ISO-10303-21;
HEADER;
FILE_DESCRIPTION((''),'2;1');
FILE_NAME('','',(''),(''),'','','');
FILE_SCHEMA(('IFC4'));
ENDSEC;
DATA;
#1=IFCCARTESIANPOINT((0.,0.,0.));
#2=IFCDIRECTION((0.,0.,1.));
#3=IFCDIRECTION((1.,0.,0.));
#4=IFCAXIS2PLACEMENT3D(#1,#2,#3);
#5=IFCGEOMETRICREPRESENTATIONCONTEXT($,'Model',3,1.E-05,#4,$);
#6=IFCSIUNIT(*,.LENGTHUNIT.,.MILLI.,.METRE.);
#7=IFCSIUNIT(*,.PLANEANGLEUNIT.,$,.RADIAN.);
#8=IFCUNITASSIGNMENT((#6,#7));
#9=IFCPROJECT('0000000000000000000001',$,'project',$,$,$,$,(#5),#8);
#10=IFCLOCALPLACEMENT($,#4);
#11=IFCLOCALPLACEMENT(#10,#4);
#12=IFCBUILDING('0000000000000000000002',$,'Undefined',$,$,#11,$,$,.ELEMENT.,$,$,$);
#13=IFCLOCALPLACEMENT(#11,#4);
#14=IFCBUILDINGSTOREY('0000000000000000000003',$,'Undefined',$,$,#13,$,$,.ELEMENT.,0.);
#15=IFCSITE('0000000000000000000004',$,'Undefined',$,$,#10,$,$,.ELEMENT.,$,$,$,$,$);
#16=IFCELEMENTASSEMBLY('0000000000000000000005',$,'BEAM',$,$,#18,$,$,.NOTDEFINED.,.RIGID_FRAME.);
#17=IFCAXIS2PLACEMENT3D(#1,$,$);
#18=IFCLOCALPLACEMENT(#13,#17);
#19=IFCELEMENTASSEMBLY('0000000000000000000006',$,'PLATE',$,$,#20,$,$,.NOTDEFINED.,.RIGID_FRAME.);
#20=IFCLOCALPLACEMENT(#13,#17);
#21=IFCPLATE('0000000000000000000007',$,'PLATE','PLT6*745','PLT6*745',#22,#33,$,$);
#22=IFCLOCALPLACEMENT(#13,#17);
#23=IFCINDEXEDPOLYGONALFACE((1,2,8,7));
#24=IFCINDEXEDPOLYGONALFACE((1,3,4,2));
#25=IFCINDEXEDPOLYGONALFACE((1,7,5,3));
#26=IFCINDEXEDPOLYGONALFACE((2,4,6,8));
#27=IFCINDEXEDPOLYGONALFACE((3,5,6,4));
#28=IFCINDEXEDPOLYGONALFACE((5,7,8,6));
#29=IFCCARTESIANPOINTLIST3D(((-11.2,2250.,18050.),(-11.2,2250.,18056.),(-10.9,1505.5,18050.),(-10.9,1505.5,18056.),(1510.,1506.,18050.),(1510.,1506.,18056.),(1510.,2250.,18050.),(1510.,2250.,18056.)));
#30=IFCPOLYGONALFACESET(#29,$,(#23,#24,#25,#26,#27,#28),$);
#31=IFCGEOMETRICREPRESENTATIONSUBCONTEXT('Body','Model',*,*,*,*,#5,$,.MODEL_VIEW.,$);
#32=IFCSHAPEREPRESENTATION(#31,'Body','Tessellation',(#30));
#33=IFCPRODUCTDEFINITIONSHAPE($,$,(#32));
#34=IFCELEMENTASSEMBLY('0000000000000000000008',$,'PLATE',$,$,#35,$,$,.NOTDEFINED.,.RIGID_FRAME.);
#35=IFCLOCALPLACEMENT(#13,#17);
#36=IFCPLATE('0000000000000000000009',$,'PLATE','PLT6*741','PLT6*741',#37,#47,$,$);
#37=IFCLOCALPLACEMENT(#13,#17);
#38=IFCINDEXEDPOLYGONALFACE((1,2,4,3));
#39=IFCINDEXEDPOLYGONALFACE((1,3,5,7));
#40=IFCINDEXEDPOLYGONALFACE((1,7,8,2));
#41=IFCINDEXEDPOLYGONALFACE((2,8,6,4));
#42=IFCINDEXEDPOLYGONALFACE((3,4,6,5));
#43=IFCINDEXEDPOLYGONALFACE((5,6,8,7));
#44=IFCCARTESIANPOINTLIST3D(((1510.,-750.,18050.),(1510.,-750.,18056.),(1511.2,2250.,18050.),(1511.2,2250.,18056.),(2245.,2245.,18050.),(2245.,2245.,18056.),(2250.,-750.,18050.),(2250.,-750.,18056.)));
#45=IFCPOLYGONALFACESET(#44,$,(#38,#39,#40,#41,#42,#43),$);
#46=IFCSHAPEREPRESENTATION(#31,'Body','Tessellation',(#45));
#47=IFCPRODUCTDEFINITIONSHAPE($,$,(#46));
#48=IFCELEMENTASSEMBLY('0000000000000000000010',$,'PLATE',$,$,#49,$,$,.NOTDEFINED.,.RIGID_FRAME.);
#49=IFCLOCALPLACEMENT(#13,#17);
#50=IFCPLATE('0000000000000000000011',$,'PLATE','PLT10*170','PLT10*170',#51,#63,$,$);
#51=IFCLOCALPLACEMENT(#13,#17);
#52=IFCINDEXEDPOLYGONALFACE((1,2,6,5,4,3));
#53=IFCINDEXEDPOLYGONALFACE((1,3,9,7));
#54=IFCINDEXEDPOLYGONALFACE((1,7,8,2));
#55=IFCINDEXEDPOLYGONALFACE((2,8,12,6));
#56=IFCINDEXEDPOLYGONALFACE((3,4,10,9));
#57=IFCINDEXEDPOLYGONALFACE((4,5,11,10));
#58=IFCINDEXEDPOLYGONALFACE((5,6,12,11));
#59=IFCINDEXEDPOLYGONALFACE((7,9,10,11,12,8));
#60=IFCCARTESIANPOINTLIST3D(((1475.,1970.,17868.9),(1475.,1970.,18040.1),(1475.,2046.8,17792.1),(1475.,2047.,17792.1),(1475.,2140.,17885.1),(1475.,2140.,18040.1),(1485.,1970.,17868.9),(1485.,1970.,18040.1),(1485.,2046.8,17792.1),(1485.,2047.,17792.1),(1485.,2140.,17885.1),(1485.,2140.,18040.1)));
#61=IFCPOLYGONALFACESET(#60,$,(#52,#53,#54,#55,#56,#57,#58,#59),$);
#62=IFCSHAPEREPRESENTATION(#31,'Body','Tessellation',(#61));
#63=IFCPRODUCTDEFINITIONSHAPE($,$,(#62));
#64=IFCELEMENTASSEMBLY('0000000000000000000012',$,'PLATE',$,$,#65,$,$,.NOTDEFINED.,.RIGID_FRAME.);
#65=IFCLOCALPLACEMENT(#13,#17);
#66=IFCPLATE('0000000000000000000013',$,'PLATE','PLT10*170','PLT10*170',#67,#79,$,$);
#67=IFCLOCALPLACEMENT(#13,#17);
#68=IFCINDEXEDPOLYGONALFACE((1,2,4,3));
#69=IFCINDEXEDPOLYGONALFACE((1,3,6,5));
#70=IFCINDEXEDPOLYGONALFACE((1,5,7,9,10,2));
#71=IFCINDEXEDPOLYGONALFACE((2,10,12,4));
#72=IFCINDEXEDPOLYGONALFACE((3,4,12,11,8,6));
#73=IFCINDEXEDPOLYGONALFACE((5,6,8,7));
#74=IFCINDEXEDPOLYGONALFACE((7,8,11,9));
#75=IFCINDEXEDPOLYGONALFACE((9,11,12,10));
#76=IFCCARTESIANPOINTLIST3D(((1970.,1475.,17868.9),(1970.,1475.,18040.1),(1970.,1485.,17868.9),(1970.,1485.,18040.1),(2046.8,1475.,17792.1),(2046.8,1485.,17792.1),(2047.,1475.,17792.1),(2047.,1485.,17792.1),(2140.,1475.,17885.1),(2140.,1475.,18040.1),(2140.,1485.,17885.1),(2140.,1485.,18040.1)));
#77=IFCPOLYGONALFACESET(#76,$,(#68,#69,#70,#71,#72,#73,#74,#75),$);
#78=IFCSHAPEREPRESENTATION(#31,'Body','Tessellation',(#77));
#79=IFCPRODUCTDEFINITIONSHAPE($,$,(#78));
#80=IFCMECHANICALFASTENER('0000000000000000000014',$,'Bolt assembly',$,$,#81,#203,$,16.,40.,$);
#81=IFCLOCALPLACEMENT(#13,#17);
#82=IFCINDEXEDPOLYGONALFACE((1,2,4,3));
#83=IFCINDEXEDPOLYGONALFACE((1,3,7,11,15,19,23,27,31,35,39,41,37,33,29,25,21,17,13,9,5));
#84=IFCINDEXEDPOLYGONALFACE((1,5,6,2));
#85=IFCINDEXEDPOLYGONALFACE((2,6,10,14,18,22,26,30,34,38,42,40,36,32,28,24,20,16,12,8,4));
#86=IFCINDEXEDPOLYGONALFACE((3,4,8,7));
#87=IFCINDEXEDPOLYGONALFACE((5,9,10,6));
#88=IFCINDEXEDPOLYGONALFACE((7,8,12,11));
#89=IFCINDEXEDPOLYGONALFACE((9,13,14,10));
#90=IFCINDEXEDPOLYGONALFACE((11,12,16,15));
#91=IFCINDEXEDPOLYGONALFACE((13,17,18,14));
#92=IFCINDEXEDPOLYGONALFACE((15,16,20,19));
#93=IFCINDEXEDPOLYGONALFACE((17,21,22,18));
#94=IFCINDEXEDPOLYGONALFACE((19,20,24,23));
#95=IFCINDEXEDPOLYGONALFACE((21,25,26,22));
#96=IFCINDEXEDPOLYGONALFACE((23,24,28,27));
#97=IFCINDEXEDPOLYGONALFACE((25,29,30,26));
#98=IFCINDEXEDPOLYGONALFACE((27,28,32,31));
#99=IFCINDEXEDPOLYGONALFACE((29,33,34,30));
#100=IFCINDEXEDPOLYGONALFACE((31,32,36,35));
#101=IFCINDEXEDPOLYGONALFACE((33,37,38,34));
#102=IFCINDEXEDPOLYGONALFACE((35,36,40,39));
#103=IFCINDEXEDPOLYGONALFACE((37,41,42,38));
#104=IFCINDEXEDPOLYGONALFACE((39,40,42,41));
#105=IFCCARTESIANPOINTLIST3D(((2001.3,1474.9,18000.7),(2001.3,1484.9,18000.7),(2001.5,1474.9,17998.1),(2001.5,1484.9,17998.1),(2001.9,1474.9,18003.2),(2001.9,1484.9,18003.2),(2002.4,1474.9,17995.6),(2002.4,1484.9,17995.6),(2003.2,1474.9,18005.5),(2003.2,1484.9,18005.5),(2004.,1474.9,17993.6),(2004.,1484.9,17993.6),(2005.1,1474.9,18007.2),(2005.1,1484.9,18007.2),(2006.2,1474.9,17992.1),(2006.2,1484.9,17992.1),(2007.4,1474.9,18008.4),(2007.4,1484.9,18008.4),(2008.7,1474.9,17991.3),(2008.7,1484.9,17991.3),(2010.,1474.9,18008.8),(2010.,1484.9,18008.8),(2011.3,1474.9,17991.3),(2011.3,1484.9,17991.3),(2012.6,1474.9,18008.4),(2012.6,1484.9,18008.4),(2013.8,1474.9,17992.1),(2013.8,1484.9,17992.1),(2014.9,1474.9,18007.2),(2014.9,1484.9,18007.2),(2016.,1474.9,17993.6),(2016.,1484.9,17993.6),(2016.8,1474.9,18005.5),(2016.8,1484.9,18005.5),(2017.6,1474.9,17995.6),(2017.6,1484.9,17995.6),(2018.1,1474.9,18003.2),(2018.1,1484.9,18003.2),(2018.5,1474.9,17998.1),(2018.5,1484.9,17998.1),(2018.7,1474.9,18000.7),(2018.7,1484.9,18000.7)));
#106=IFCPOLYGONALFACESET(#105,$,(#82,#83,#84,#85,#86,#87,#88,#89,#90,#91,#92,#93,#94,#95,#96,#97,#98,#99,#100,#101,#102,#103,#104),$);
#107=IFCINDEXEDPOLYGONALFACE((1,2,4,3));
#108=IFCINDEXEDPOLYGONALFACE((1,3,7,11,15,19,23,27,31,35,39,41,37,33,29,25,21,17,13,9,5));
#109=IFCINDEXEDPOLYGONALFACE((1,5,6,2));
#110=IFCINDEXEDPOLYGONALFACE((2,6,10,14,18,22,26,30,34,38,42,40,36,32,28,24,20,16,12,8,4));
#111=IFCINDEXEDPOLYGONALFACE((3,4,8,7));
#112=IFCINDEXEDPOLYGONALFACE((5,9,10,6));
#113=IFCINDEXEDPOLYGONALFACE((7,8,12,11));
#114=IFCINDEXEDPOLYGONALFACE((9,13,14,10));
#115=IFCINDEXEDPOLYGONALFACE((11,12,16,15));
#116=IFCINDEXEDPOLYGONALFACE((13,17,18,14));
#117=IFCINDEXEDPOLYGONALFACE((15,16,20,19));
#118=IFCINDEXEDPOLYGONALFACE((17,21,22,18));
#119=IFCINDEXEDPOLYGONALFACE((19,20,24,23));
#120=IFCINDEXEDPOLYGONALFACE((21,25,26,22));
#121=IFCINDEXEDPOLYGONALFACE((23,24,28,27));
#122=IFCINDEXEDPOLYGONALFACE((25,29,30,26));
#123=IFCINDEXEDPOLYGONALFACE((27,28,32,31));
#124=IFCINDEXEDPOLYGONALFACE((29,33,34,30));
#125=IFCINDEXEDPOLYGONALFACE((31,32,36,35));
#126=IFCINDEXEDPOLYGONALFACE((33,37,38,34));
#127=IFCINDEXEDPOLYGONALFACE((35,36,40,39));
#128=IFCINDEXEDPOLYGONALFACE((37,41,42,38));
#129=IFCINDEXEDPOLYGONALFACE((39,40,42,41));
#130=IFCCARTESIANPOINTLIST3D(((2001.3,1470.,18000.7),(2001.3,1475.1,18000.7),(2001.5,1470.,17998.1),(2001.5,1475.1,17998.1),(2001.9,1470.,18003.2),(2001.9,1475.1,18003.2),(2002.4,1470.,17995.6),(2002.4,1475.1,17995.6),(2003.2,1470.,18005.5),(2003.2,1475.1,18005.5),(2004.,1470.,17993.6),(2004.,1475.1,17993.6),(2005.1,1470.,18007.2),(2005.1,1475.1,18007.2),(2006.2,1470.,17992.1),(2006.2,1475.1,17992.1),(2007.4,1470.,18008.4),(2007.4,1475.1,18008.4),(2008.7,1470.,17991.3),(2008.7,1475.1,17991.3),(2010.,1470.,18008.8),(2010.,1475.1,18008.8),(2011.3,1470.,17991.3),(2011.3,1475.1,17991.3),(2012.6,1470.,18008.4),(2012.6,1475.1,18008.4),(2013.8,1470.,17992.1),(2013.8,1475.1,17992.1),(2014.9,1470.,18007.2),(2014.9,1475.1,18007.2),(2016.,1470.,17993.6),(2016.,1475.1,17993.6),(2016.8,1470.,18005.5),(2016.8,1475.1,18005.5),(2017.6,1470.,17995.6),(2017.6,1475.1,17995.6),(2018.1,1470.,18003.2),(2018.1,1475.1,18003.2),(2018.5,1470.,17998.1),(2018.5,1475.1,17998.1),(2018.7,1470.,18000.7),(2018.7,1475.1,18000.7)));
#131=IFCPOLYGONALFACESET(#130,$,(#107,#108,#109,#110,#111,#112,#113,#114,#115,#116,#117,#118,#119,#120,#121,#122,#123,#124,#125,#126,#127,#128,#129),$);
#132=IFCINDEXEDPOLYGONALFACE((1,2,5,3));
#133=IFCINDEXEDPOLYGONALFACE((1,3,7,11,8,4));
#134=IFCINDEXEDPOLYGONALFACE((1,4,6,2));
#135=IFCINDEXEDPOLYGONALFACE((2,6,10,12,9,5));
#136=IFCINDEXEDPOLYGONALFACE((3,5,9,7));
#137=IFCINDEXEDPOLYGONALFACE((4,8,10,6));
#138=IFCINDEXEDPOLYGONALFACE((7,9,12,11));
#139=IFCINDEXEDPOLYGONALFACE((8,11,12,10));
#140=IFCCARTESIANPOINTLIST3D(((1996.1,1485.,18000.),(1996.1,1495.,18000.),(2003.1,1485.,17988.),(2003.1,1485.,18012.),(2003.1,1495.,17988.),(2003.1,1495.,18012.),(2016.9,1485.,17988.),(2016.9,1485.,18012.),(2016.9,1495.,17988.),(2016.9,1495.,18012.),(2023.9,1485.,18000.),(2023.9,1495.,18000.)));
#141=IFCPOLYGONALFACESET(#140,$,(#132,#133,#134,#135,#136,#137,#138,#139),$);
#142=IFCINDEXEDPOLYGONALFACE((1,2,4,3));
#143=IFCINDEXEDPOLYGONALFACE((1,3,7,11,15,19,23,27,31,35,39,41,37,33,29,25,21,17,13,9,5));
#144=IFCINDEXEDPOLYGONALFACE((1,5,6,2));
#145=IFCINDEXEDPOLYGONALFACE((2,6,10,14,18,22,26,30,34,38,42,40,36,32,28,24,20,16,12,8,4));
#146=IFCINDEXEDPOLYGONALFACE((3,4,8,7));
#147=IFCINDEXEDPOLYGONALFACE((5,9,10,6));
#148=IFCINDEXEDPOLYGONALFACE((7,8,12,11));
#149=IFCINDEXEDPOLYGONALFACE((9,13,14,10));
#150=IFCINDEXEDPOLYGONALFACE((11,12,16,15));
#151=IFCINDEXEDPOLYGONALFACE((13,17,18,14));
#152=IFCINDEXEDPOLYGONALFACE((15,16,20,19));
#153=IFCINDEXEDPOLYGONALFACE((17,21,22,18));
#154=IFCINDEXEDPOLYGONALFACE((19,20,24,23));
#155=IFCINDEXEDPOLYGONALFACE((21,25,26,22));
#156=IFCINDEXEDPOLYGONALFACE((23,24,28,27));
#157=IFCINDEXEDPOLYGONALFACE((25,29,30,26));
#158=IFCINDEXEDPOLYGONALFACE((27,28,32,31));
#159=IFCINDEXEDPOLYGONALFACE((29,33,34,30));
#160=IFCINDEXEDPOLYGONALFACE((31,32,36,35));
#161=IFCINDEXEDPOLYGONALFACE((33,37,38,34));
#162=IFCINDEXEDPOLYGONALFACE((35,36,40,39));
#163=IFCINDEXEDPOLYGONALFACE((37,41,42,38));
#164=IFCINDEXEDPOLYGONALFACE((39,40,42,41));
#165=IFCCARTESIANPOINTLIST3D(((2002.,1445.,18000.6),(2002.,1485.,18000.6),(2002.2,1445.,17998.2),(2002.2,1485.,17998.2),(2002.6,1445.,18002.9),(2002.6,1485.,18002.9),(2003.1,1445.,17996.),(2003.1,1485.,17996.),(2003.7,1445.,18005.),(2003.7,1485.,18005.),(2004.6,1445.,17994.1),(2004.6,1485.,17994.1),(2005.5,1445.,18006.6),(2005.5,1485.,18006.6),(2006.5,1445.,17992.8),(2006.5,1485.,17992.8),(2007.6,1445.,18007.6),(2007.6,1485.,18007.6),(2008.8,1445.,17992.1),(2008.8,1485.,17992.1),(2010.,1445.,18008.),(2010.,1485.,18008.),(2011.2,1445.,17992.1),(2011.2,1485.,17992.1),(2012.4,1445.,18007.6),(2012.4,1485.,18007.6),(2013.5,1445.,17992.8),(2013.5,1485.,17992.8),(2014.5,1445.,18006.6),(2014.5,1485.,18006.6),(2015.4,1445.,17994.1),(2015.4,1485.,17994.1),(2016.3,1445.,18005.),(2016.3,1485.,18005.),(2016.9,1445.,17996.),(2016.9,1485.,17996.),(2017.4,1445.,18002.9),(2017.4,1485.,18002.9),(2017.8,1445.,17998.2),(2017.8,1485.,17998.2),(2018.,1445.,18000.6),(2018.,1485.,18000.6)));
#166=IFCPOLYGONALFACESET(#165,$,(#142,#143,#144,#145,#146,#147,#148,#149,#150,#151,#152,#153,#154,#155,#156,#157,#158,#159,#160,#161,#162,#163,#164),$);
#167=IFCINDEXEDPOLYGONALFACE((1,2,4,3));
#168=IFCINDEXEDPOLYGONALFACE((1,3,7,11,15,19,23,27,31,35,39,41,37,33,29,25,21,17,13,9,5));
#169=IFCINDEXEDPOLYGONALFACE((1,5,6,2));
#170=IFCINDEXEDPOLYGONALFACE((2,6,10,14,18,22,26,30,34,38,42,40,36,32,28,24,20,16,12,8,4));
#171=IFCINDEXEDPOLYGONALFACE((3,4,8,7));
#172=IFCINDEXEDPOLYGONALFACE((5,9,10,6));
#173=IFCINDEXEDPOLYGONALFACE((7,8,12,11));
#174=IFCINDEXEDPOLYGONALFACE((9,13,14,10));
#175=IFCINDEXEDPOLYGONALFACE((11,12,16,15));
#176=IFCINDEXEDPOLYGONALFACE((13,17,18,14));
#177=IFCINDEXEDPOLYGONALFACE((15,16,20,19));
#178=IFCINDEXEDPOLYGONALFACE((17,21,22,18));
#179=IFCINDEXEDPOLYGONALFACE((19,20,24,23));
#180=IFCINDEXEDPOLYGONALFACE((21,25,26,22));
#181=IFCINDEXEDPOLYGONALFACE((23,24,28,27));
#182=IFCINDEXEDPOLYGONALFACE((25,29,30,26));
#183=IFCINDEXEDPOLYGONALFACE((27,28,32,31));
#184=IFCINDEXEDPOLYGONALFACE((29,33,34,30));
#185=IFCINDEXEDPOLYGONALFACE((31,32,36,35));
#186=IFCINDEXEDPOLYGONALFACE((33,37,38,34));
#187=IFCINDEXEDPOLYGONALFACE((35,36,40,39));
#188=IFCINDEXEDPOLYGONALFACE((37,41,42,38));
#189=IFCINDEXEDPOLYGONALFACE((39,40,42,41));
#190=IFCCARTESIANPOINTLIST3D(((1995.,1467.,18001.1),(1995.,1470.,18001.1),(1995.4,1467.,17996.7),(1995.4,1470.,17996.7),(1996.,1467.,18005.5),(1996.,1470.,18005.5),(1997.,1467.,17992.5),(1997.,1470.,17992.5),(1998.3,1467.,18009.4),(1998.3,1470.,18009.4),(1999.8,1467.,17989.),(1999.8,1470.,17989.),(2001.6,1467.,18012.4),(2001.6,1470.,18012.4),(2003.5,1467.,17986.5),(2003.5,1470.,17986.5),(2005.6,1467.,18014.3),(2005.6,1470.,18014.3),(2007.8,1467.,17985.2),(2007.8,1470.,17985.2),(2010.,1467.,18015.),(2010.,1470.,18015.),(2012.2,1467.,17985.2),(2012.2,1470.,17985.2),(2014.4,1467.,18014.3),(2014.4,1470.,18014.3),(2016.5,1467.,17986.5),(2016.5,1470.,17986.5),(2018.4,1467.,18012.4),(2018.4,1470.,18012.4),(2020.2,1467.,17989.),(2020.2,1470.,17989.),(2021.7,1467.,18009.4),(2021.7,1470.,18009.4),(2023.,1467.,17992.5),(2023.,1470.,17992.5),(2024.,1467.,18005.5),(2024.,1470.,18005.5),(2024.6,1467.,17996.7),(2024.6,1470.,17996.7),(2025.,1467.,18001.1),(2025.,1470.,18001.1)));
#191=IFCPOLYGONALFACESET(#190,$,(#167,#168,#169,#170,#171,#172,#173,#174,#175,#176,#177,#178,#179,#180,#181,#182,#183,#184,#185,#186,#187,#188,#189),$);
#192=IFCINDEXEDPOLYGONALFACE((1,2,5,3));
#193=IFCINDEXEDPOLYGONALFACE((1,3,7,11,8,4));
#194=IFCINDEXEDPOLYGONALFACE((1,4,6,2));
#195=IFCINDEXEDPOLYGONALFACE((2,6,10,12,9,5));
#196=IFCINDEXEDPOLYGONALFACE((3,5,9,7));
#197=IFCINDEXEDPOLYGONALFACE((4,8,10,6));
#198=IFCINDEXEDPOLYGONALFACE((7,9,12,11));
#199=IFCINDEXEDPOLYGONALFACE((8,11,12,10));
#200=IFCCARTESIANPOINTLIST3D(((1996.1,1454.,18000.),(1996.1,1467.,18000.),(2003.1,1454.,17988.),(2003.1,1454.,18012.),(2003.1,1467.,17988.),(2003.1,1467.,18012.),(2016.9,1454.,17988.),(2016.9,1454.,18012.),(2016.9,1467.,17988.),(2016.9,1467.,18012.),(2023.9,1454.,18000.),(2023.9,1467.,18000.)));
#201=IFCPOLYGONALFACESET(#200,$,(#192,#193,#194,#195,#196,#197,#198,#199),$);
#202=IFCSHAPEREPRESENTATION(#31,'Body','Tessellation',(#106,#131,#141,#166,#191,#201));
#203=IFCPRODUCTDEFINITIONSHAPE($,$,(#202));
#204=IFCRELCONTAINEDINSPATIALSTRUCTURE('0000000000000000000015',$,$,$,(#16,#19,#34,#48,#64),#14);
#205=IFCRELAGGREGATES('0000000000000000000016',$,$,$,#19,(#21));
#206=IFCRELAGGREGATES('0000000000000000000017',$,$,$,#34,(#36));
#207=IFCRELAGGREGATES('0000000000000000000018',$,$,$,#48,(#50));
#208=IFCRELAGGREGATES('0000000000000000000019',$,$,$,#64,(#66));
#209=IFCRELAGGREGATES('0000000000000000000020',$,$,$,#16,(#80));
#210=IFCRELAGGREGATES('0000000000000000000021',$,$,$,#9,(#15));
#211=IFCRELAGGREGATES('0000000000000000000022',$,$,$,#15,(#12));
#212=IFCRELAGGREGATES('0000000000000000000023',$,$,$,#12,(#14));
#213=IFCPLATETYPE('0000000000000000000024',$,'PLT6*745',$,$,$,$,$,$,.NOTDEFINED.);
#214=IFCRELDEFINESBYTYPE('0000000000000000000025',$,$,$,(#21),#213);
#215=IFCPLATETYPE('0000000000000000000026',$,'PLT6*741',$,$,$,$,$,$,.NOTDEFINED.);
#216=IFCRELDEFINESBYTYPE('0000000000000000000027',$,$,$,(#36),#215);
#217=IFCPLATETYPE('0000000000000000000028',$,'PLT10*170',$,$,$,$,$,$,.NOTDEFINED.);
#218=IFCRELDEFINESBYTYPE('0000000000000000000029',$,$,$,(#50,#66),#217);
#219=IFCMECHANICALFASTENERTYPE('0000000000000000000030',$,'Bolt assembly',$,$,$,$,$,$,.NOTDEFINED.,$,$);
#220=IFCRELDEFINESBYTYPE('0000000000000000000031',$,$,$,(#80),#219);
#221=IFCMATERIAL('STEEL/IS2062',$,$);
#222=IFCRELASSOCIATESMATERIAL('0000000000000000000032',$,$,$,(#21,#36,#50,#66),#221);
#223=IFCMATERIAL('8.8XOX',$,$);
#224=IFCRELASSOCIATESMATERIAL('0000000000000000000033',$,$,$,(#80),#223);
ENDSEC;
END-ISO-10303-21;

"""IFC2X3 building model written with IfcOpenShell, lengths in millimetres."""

from ifc_helpers import new_model, si_unit, frame, origin_with_axes, origin_2d_with_axis, place, context, subcontext, project, spatial, polyline, circle, outline, extrude, source, transform, mapped, material, type_object, element, aggregate, save


model = new_model("IFC2X3")

# Units and contexts
model_context = context("Model", 3, precision=1e-05, world=origin_with_axes())
body_context = subcontext(model_context, "Body", "Model", "MODEL_VIEW")
ifc_project = project(units=[si_unit("LENGTHUNIT", "METRE", prefix="MILLI"), si_unit("PLANEANGLEUNIT", "RADIAN")], contexts=[model_context])

# Site, building, storey
site_placement = place(None, origin_with_axes())
site = spatial("IfcSite", under=ifc_project, at=site_placement, Name="Undefined", CompositionType="ELEMENT")
building_placement = place(site_placement, origin_with_axes())
building = spatial("IfcBuilding", under=site, at=building_placement, Name="Undefined", CompositionType="ELEMENT")
storey_placement = place(building_placement, origin_with_axes())
storey = spatial("IfcBuildingStorey", under=building, at=storey_placement, Name="Undefined", CompositionType="ELEMENT", Elevation=0.0)

# Shared definitions
ifc_material_1 = material(Name="STEEL/IS2062")

# Element assembly
assembly_1_placement = place(storey_placement, origin_with_axes())
assembly_1 = element("IfcElementAssembly", 1, at=assembly_1_placement, inside=storey, Name="BEAM", AssemblyPlace="NOTDEFINED", PredefinedType="RIGID_FRAME")

# Element assemblies, plates
assembly_2_placement = place(storey_placement, origin_with_axes())
assembly_2 = element("IfcElementAssembly", 2, at=assembly_2_placement, inside=storey, Name="PLATE", AssemblyPlace="NOTDEFINED", PredefinedType="RIGID_FRAME")
plate_type_1 = type_object("IfcPlateType", Name="PLT6*745", PredefinedType="NOTDEFINED")
plate_1_placement = place(assembly_2_placement, frame((1510.0, 2250.0, 18053.0), z_axis=(0.0, 0.0, 1.0), x_axis=(-1.0, -0.000026, 0.0)))
plate_1 = element("IfcPlate", 3, at=plate_1_placement, type_object=plate_type_1, material=ifc_material_1, Name="PLATE", Description="PLT6*745", ObjectType="PLT6*745", context=body_context, shape_type="SweptSolid", body=[
    extrude(outline(polyline([(0.0, 0.0), (1521.2, 0.0), (1520.9, 744.5), (0.0, 744.0), (0.0, 0.0)])), frame((0.0, 0.0, -3.0), z_axis=(0.0, 0.0, 1.0), x_axis=(1.0, 0.0, 0.0)), (0.0, 0.0, 1.0), 6.0),
])
aggregate(assembly_2, [plate_1])
assembly_3_placement = place(storey_placement, origin_with_axes())
assembly_3 = element("IfcElementAssembly", 4, at=assembly_3_placement, inside=storey, Name="PLATE", AssemblyPlace="NOTDEFINED", PredefinedType="RIGID_FRAME")
plate_type_2 = type_object("IfcPlateType", Name="PLT6*741", PredefinedType="NOTDEFINED")
plate_2_placement = place(assembly_3_placement, frame((1510.0, 2250.0, 18053.0), z_axis=(0.0, 0.0, -1.0), x_axis=(0.999977, -0.006803, 0.0)))
plate_2 = element("IfcPlate", 5, at=plate_2_placement, type_object=plate_type_2, material=ifc_material_1, Name="PLATE", Description="PLT6*741", ObjectType="PLT6*741", context=body_context, shape_type="SweptSolid", body=[
    extrude(outline(polyline([(0.0, 0.0), (735.0, 0.0), (760.4, 2994.9), (20.4, 2999.9), (1.2, 0.0), (0.0, 0.0)])), frame((0.0, 0.0, -3.0), z_axis=(0.0, 0.0, 1.0), x_axis=(1.0, 0.0, 0.0)), (0.0, 0.0, 1.0), 6.0),
])
aggregate(assembly_3, [plate_2])
assembly_4_placement = place(storey_placement, origin_with_axes())
assembly_4 = element("IfcElementAssembly", 6, at=assembly_4_placement, inside=storey, Name="PLATE", AssemblyPlace="NOTDEFINED", PredefinedType="RIGID_FRAME")
plate_type_3 = type_object("IfcPlateType", Name="PLT10*170", PredefinedType="NOTDEFINED")
plate_3_placement = place(assembly_4_placement, frame((1480.0, 2140.0, 18040.1), z_axis=(-1.0, 0.0, 0.0), x_axis=(0.0, 0.0, -1.0)))
plate_3 = element("IfcPlate", 7, at=plate_3_placement, type_object=plate_type_3, material=ifc_material_1, Name="PLATE", Description="PLT10*170", ObjectType="PLT10*170", context=body_context, shape_type="SweptSolid", body=[
    extrude(outline(polyline([(0.0, 0.0), (155.0, 0.0), (248.0, 93.0), (248.0, 93.2), (171.2, 170.0), (0.0, 170.0), (0.0, 0.0)])), frame((0.0, 0.0, -5.0), z_axis=(0.0, 0.0, 1.0), x_axis=(1.0, 0.0, 0.0)), (0.0, 0.0, 1.0), 10.0),
])
aggregate(assembly_4, [plate_3])
assembly_5_placement = place(storey_placement, origin_with_axes())
assembly_5 = element("IfcElementAssembly", 8, at=assembly_5_placement, inside=storey, Name="PLATE", AssemblyPlace="NOTDEFINED", PredefinedType="RIGID_FRAME")
plate_4_placement = place(assembly_5_placement, frame((2140.0, 1480.0, 18040.1), z_axis=(0.0, 1.0, 0.0), x_axis=(0.0, 0.0, -1.0)))
plate_4 = element("IfcPlate", 9, at=plate_4_placement, type_object=plate_type_3, material=ifc_material_1, Name="PLATE", Description="PLT10*170", ObjectType="PLT10*170", context=body_context, shape_type="SweptSolid", body=[
    extrude(outline(polyline([(0.0, 0.0), (155.0, 0.0), (248.0, 93.0), (248.0, 93.2), (171.2, 170.0), (0.0, 170.0), (0.0, 0.0)])), frame((0.0, 0.0, -5.0), z_axis=(0.0, 0.0, 1.0), x_axis=(1.0, 0.0, 0.0)), (0.0, 0.0, 1.0), 10.0),
])
aggregate(assembly_5, [plate_4])

# Mechanical fastener
ifc_material_2 = material(Name="8.8XOX")
mechanical_fastener_type = type_object("IfcMechanicalFastenerType", Name="Bolt assembly")
shared_shape_1 = source(origin_with_axes(), body_context, "Body", "SweptSolid", [
    extrude(circle(Radius=8.8, at=origin_2d_with_axis()), frame((0.0, 15.1, 0.0), z_axis=(0.0, 1.0, 0.0), x_axis=(1.0, 0.0, 0.0)), (0.0, 0.0, 1.0), 10.0),
    extrude(circle(Radius=8.8, at=origin_2d_with_axis()), frame((0.0, 24.9, 0.0), z_axis=(0.0, 1.0, 0.0), x_axis=(1.0, 0.0, 0.0)), (0.0, 0.0, 1.0), 5.1),
    extrude(outline(polyline([(12.0, -6.9), (12.0, 6.9), (0.0, 13.9), (-12.0, 6.9), (-12.0, -6.9), (0.0, -13.9), (12.0, -6.9)])), frame((0.0, 5.0, 0.0), z_axis=(0.0, 1.0, 0.0), x_axis=(1.0, 0.0, 0.0)), (0.0, 0.0, 1.0), 10.0),
    extrude(circle(Radius=8.0, at=origin_2d_with_axis()), frame((0.0, 15.0, 0.0), z_axis=(0.0, 1.0, 0.0), x_axis=(1.0, 0.0, 0.0)), (0.0, 0.0, 1.0), 40.0),
    extrude(circle(Radius=15.0, at=origin_2d_with_axis()), frame((0.0, 30.0, 0.0), z_axis=(0.0, 1.0, 0.0), x_axis=(1.0, 0.0, 0.0)), (0.0, 0.0, 1.0), 3.0),
    extrude(outline(polyline([(12.0, -6.9), (12.0, 6.9), (0.0, 13.9), (-12.0, 6.9), (-12.0, -6.9), (0.0, -13.9), (12.0, -6.9)])), frame((0.0, 33.0, 0.0), z_axis=(0.0, 1.0, 0.0), x_axis=(1.0, 0.0, 0.0)), (0.0, 0.0, 1.0), 13.0),
])
mechanical_fastener_1_placement = place(assembly_1_placement, frame((2010.0, 1500.0, 18000.0), z_axis=(1.0, 0.0, 0.0), x_axis=(0.0, 0.0, 1.0)))
mechanical_fastener_1 = element("IfcMechanicalFastener", 10, at=mechanical_fastener_1_placement, type_object=mechanical_fastener_type, material=ifc_material_2, Name="Bolt assembly", NominalDiameter=16.0, NominalLength=40.0, context=body_context, shape_type="MappedRepresentation", body=[
    mapped(shared_shape_1, transform((0.0, 0.0, 0.0))),
])
aggregate(assembly_1, [mechanical_fastener_1])

save(model, "model.ifc")
